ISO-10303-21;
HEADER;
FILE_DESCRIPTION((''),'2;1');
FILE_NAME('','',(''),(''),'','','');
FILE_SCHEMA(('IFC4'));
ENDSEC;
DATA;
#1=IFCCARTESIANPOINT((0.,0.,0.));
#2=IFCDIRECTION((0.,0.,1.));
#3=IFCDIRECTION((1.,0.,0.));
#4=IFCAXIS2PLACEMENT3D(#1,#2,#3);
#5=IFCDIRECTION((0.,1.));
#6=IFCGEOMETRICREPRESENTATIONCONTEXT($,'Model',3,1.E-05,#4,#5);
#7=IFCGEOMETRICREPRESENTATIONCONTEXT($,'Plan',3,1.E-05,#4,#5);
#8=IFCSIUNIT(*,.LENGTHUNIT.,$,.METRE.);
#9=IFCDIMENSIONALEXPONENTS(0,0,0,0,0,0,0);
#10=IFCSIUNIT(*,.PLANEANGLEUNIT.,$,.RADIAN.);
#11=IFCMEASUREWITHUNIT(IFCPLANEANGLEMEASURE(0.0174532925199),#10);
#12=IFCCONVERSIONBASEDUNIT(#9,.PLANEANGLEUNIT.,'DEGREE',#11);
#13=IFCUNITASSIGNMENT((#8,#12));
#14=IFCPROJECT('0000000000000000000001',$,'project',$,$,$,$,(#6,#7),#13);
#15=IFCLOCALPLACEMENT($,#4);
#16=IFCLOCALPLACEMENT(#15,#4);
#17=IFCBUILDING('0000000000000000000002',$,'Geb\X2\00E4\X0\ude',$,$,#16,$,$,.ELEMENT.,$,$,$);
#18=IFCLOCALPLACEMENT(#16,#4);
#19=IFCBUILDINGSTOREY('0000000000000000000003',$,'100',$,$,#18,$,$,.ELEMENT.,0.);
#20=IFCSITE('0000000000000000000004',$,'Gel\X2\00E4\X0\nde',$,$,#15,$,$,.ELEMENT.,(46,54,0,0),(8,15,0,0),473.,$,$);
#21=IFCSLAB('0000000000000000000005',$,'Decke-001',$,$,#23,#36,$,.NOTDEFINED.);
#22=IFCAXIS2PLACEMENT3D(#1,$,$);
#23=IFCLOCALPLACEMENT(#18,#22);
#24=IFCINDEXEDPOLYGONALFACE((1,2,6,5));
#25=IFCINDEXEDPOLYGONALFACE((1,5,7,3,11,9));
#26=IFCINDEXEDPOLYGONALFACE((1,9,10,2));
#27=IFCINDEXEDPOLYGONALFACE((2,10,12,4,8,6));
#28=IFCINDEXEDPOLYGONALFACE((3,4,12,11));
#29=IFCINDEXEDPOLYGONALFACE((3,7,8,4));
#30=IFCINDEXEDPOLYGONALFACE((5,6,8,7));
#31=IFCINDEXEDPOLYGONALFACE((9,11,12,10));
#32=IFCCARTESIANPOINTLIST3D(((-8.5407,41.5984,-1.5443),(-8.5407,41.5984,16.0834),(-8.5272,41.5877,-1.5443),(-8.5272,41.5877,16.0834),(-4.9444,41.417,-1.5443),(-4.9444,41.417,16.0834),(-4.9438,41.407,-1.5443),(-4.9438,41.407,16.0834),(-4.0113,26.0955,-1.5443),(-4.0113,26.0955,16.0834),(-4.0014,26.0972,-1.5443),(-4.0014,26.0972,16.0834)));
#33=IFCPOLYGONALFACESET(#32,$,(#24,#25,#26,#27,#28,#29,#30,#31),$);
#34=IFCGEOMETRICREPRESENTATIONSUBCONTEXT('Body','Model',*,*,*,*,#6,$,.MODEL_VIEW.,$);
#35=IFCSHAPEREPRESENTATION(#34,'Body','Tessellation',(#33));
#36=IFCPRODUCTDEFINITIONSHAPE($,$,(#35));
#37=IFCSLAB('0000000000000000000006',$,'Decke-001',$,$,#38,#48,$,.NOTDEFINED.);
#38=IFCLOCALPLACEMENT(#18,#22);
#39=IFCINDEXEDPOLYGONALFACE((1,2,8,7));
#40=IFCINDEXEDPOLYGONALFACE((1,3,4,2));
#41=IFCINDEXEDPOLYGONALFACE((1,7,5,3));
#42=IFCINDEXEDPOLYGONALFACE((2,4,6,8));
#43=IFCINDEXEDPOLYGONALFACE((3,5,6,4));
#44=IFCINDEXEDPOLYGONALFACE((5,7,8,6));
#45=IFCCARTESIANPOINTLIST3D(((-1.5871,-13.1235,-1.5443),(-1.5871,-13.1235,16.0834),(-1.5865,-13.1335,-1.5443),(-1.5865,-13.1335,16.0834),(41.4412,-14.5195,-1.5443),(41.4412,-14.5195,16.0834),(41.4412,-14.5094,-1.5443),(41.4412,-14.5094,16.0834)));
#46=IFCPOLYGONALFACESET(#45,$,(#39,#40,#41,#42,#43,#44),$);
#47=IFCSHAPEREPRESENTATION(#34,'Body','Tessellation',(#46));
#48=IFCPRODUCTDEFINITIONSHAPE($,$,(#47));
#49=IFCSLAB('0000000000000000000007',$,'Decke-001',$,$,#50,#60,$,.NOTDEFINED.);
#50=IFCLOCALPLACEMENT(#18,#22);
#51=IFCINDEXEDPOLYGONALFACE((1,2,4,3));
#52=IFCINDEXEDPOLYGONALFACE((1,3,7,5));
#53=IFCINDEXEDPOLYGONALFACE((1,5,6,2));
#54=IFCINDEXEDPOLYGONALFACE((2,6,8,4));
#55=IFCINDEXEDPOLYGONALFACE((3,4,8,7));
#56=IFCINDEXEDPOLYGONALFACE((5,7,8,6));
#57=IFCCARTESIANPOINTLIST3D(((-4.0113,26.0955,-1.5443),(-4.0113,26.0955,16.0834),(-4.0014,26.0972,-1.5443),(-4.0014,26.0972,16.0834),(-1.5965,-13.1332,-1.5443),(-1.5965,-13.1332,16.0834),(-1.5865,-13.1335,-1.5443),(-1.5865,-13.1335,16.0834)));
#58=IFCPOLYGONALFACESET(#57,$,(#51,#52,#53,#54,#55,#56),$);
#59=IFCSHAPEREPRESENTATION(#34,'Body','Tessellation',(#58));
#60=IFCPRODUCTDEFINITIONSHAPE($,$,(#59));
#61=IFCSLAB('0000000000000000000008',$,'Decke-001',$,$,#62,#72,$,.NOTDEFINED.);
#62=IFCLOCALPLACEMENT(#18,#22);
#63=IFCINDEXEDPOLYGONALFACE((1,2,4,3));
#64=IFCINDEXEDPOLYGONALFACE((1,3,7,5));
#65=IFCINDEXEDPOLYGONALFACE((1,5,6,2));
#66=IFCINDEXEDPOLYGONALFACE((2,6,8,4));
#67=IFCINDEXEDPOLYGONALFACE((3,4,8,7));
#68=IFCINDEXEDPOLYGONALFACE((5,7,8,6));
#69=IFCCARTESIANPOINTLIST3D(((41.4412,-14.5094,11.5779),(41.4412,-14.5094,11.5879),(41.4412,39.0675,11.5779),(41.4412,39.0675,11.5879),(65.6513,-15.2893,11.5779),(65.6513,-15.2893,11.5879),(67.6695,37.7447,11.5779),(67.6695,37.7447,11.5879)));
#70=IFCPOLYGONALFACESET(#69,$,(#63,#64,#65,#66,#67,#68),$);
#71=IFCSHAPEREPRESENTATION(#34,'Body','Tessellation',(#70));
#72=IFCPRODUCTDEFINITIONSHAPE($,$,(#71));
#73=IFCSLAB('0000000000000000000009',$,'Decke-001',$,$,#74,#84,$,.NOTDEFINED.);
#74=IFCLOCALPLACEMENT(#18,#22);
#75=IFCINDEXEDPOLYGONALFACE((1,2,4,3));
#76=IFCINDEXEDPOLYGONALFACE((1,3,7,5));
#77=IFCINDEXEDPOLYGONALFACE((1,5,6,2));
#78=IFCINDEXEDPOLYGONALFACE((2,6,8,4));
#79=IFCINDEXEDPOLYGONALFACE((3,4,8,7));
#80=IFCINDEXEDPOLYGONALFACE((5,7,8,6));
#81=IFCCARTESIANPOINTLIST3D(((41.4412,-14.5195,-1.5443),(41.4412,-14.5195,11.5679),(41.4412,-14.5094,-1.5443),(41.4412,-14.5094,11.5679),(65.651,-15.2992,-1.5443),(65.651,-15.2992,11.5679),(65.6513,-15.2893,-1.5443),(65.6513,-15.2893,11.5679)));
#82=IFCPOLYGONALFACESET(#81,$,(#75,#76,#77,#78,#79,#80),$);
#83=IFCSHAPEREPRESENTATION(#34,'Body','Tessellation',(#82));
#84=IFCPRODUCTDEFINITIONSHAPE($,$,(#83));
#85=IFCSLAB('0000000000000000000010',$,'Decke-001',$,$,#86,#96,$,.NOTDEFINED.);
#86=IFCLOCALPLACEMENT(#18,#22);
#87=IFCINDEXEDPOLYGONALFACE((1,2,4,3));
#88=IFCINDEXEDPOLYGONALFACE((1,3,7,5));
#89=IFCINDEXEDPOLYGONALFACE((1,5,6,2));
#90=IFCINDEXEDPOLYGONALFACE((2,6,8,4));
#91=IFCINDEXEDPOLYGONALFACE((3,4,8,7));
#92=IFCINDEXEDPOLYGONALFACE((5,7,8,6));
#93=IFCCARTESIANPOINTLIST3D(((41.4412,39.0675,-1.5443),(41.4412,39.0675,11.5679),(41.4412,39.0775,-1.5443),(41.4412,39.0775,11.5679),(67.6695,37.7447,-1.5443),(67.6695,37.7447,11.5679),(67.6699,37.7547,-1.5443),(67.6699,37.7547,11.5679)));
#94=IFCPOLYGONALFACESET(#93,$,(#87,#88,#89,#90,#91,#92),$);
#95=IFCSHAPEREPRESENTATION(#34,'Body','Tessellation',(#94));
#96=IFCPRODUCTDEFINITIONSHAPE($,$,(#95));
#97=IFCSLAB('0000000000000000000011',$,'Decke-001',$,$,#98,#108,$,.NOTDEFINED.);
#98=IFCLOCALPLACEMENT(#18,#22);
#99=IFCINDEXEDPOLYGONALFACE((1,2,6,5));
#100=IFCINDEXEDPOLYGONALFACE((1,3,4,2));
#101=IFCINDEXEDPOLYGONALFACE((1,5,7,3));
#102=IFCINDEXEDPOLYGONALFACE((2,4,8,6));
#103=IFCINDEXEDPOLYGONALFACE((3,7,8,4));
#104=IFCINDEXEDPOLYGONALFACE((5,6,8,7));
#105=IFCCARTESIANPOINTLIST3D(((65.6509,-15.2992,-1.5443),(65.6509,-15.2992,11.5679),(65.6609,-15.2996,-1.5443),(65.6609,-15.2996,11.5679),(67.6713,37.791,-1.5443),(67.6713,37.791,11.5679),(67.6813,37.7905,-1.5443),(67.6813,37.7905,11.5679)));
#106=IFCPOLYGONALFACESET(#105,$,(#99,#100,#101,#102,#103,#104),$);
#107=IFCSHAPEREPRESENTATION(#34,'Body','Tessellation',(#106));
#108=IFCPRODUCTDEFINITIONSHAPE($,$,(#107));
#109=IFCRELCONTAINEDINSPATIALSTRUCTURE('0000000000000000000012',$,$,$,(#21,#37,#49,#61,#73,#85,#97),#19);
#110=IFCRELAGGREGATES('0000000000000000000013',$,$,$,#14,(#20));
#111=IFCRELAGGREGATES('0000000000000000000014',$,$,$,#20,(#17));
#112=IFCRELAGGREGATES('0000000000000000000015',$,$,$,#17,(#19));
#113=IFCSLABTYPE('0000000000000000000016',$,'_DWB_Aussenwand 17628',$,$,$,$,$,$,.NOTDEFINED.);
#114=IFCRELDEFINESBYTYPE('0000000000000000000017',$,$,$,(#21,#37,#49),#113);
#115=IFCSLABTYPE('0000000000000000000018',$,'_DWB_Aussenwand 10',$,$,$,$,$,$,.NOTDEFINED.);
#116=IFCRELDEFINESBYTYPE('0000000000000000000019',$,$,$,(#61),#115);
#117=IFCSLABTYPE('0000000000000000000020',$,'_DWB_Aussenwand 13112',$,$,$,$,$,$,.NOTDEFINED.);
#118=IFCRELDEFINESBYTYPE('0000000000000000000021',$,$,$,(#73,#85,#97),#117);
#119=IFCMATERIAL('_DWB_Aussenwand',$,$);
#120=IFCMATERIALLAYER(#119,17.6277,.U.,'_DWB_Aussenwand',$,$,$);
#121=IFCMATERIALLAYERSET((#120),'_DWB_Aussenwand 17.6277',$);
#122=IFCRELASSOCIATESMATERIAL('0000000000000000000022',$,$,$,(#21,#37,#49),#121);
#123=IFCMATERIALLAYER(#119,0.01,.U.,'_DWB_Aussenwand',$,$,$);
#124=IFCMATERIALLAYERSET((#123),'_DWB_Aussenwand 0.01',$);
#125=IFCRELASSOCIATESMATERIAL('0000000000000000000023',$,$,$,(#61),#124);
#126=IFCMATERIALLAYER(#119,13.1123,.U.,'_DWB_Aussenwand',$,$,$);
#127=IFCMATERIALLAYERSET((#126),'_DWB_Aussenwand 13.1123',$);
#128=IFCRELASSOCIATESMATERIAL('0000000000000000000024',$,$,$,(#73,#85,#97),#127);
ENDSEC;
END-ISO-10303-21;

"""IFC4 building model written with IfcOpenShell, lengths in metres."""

from ifc_helpers import new_model, entity, si_unit, converted_unit, direction, frame, origin_with_axes, place, context, subcontext, project, spatial, line, indexed_curve, outline, extrude, material, layer, layer_set, layer_usage, type_object, element, save


model = new_model("IFC4")

# Units and contexts
model_context = context("Model", 3, precision=1e-05, world=origin_with_axes(), true_north=direction((0.0, 1.0)))
plan_context = context("Plan", 3, precision=1e-05, world=origin_with_axes(), true_north=direction((0.0, 1.0)))
body_context = subcontext(model_context, "Body", "Model", "MODEL_VIEW")
ifc_project = project(units=[si_unit("LENGTHUNIT", "METRE"), converted_unit("PLANEANGLEUNIT", "DEGREE", entity("IfcPlaneAngleMeasure", 0.0174532925199), si_unit("PLANEANGLEUNIT", "RADIAN"), dimensions=[0, 0, 0, 0, 0, 0, 0])], contexts=[model_context, plan_context])

# Site, building, storey
site_placement = place(None, origin_with_axes())
site = spatial("IfcSite", under=ifc_project, at=site_placement, Name="Gelände", CompositionType="ELEMENT", RefLatitude=(46, 54, 0, 0), RefLongitude=(8, 15, 0, 0), RefElevation=473.0)
building_placement = place(site_placement, origin_with_axes())
building = spatial("IfcBuilding", under=site, at=building_placement, Name="Gebäude", CompositionType="ELEMENT")
storey_placement = place(building_placement, origin_with_axes())
storey = spatial("IfcBuildingStorey", under=building, at=storey_placement, Name="100", CompositionType="ELEMENT", Elevation=0.0)

# Slabs
ifc_material = material(Name="_DWB_Aussenwand")
ifc_layer_1 = layer(ifc_material, 17.6277, ventilated="UNKNOWN", Name="_DWB_Aussenwand")
ifc_layer_set_1 = layer_set([ifc_layer_1], Name="_DWB_Aussenwand 17.6277")
ifc_layer_usage_1 = layer_usage(ifc_layer_set_1, "AXIS3", "NEGATIVE", 17.6277)
slab_type_1 = type_object("IfcSlabType", Name="_DWB_Aussenwand 17628", PredefinedType="NOTDEFINED")
slab_1_placement = place(storey_placement, frame((-4.9444, 41.417, 16.0834), z_axis=(0.0, 0.0, 1.0), x_axis=(1.0, 0.0, 0.0)))
element("IfcSlab", 1, at=slab_1_placement, inside=storey, type_object=slab_type_1, material=ifc_layer_usage_1, Name="Decke-001", PredefinedType="NOTDEFINED", context=body_context, shape_type="SweptSolid", body=[
    extrude(outline(indexed_curve([(0.0, 0.0), (-3.5963, 0.1814), (0.9331, -15.3216), (0.943, -15.3198), (-3.5828, 0.1707), (0.0006, -0.01)], segments=[line(1, 2, 3, 4, 5, 6, 1)])), frame((0.0, 0.0, -17.6277), z_axis=(0.0, 0.0, 1.0), x_axis=(1.0, 0.0, 0.0)), (0.0, 0.0, 1.0), 17.6277),
])
ifc_layer_usage_2 = layer_usage(ifc_layer_set_1, "AXIS3", "NEGATIVE", 17.6277)
slab_2_placement = place(storey_placement, frame((41.4412, -14.5094, 16.0834), z_axis=(0.0, 0.0, 1.0), x_axis=(1.0, 0.0, 0.0)))
element("IfcSlab", 2, at=slab_2_placement, inside=storey, type_object=slab_type_1, material=ifc_layer_usage_2, Name="Decke-001", PredefinedType="NOTDEFINED", context=body_context, shape_type="SweptSolid", body=[
    extrude(outline(indexed_curve([(0.0, 0.0), (-43.0283, 1.3859), (-43.0277, 1.3759), (0.0, -0.01)], segments=[line(1, 2, 3, 4, 1)])), frame((0.0, 0.0, -17.6277), z_axis=(0.0, 0.0, 1.0), x_axis=(1.0, 0.0, 0.0)), (0.0, 0.0, 1.0), 17.6277),
])
ifc_layer_usage_3 = layer_usage(ifc_layer_set_1, "AXIS3", "NEGATIVE", 17.6277)
slab_3_placement = place(storey_placement, frame((-4.0113, 26.0955, 16.0834), z_axis=(0.0, 0.0, 1.0), x_axis=(1.0, 0.0, 0.0)))
element("IfcSlab", 3, at=slab_3_placement, inside=storey, type_object=slab_type_1, material=ifc_layer_usage_3, Name="Decke-001", PredefinedType="NOTDEFINED", context=body_context, shape_type="SweptSolid", body=[
    extrude(outline(indexed_curve([(0.0, 0.0), (2.4148, -39.2287), (2.4248, -39.229), (0.0099, 0.0017)], segments=[line(1, 2, 3, 4, 1)])), frame((0.0, 0.0, -17.6277), z_axis=(0.0, 0.0, 1.0), x_axis=(1.0, 0.0, 0.0)), (0.0, 0.0, 1.0), 17.6277),
])
ifc_layer_2 = layer(ifc_material, 0.01, ventilated="UNKNOWN", Name="_DWB_Aussenwand")
ifc_layer_set_2 = layer_set([ifc_layer_2], Name="_DWB_Aussenwand 0.01")
slab_type_2 = type_object("IfcSlabType", Name="_DWB_Aussenwand 10", PredefinedType="NOTDEFINED")
ifc_layer_usage_4 = layer_usage(ifc_layer_set_2, "AXIS3", "NEGATIVE", 0.01)
slab_4_placement = place(storey_placement, frame((41.4412, -14.5094, 11.5779), z_axis=(0.0, 0.0, 1.0), x_axis=(1.0, 0.0, 0.0)))
element("IfcSlab", 4, at=slab_4_placement, inside=storey, type_object=slab_type_2, material=ifc_layer_usage_4, Name="Decke-001", PredefinedType="NOTDEFINED", context=body_context, shape_type="SweptSolid", body=[
    extrude(outline(indexed_curve([(0.0, 0.0), (24.2102, -0.7798), (26.2284, 52.2541), (0.0, 53.577)], segments=[line(1, 2, 3, 4, 1)])), origin_with_axes(), (0.0, 0.0, 1.0), 0.01),
])
ifc_layer_3 = layer(ifc_material, 13.1123, ventilated="UNKNOWN", Name="_DWB_Aussenwand")
ifc_layer_set_3 = layer_set([ifc_layer_3], Name="_DWB_Aussenwand 13.1123")
ifc_layer_usage_5 = layer_usage(ifc_layer_set_3, "AXIS3", "NEGATIVE", 13.1123)
slab_type_3 = type_object("IfcSlabType", Name="_DWB_Aussenwand 13112", PredefinedType="NOTDEFINED")
slab_5_placement = place(storey_placement, frame((41.4412, -14.5094, 11.5679), z_axis=(0.0, 0.0, 1.0), x_axis=(1.0, 0.0, 0.0)))
element("IfcSlab", 5, at=slab_5_placement, inside=storey, type_object=slab_type_3, material=ifc_layer_usage_5, Name="Decke-001", PredefinedType="NOTDEFINED", context=body_context, shape_type="SweptSolid", body=[
    extrude(outline(indexed_curve([(0.0, 0.0), (0.0, -0.01), (24.2098, -0.7898), (24.2102, -0.7798)], segments=[line(1, 2, 3, 4, 1)])), frame((0.0, 0.0, -13.1123), z_axis=(0.0, 0.0, 1.0), x_axis=(1.0, 0.0, 0.0)), (0.0, 0.0, 1.0), 13.1123),
])
ifc_layer_usage_6 = layer_usage(ifc_layer_set_3, "AXIS3", "NEGATIVE", 13.1123)
slab_6_placement = place(storey_placement, frame((67.6699, 37.7547, 11.5679), z_axis=(0.0, 0.0, 1.0), x_axis=(1.0, 0.0, 0.0)))
element("IfcSlab", 6, at=slab_6_placement, inside=storey, type_object=slab_type_3, material=ifc_layer_usage_6, Name="Decke-001", PredefinedType="NOTDEFINED", context=body_context, shape_type="SweptSolid", body=[
    extrude(outline(indexed_curve([(0.0, 0.0), (-26.2288, 1.3229), (-26.2288, 1.3129), (-0.0004, -0.01)], segments=[line(1, 2, 3, 4, 1)])), frame((0.0, 0.0, -13.1123), z_axis=(0.0, 0.0, 1.0), x_axis=(1.0, 0.0, 0.0)), (0.0, 0.0, 1.0), 13.1123),
])
ifc_layer_usage_7 = layer_usage(ifc_layer_set_3, "AXIS3", "NEGATIVE", 13.1123)
slab_7_placement = place(storey_placement, frame((65.6509, -15.2992, 11.5679), z_axis=(0.0, 0.0, 1.0), x_axis=(1.0, 0.0, 0.0)))
element("IfcSlab", 7, at=slab_7_placement, inside=storey, type_object=slab_type_3, material=ifc_layer_usage_7, Name="Decke-001", PredefinedType="NOTDEFINED", context=body_context, shape_type="SweptSolid", body=[
    extrude(outline(indexed_curve([(0.0, 0.0), (0.01, -0.0003), (2.0303, 53.0898), (2.0203, 53.0903)], segments=[line(1, 2, 3, 4, 1)])), frame((0.0, 0.0, -13.1123), z_axis=(0.0, 0.0, 1.0), x_axis=(1.0, 0.0, 0.0)), (0.0, 0.0, 1.0), 13.1123),
])

save(model, "model.ifc")
